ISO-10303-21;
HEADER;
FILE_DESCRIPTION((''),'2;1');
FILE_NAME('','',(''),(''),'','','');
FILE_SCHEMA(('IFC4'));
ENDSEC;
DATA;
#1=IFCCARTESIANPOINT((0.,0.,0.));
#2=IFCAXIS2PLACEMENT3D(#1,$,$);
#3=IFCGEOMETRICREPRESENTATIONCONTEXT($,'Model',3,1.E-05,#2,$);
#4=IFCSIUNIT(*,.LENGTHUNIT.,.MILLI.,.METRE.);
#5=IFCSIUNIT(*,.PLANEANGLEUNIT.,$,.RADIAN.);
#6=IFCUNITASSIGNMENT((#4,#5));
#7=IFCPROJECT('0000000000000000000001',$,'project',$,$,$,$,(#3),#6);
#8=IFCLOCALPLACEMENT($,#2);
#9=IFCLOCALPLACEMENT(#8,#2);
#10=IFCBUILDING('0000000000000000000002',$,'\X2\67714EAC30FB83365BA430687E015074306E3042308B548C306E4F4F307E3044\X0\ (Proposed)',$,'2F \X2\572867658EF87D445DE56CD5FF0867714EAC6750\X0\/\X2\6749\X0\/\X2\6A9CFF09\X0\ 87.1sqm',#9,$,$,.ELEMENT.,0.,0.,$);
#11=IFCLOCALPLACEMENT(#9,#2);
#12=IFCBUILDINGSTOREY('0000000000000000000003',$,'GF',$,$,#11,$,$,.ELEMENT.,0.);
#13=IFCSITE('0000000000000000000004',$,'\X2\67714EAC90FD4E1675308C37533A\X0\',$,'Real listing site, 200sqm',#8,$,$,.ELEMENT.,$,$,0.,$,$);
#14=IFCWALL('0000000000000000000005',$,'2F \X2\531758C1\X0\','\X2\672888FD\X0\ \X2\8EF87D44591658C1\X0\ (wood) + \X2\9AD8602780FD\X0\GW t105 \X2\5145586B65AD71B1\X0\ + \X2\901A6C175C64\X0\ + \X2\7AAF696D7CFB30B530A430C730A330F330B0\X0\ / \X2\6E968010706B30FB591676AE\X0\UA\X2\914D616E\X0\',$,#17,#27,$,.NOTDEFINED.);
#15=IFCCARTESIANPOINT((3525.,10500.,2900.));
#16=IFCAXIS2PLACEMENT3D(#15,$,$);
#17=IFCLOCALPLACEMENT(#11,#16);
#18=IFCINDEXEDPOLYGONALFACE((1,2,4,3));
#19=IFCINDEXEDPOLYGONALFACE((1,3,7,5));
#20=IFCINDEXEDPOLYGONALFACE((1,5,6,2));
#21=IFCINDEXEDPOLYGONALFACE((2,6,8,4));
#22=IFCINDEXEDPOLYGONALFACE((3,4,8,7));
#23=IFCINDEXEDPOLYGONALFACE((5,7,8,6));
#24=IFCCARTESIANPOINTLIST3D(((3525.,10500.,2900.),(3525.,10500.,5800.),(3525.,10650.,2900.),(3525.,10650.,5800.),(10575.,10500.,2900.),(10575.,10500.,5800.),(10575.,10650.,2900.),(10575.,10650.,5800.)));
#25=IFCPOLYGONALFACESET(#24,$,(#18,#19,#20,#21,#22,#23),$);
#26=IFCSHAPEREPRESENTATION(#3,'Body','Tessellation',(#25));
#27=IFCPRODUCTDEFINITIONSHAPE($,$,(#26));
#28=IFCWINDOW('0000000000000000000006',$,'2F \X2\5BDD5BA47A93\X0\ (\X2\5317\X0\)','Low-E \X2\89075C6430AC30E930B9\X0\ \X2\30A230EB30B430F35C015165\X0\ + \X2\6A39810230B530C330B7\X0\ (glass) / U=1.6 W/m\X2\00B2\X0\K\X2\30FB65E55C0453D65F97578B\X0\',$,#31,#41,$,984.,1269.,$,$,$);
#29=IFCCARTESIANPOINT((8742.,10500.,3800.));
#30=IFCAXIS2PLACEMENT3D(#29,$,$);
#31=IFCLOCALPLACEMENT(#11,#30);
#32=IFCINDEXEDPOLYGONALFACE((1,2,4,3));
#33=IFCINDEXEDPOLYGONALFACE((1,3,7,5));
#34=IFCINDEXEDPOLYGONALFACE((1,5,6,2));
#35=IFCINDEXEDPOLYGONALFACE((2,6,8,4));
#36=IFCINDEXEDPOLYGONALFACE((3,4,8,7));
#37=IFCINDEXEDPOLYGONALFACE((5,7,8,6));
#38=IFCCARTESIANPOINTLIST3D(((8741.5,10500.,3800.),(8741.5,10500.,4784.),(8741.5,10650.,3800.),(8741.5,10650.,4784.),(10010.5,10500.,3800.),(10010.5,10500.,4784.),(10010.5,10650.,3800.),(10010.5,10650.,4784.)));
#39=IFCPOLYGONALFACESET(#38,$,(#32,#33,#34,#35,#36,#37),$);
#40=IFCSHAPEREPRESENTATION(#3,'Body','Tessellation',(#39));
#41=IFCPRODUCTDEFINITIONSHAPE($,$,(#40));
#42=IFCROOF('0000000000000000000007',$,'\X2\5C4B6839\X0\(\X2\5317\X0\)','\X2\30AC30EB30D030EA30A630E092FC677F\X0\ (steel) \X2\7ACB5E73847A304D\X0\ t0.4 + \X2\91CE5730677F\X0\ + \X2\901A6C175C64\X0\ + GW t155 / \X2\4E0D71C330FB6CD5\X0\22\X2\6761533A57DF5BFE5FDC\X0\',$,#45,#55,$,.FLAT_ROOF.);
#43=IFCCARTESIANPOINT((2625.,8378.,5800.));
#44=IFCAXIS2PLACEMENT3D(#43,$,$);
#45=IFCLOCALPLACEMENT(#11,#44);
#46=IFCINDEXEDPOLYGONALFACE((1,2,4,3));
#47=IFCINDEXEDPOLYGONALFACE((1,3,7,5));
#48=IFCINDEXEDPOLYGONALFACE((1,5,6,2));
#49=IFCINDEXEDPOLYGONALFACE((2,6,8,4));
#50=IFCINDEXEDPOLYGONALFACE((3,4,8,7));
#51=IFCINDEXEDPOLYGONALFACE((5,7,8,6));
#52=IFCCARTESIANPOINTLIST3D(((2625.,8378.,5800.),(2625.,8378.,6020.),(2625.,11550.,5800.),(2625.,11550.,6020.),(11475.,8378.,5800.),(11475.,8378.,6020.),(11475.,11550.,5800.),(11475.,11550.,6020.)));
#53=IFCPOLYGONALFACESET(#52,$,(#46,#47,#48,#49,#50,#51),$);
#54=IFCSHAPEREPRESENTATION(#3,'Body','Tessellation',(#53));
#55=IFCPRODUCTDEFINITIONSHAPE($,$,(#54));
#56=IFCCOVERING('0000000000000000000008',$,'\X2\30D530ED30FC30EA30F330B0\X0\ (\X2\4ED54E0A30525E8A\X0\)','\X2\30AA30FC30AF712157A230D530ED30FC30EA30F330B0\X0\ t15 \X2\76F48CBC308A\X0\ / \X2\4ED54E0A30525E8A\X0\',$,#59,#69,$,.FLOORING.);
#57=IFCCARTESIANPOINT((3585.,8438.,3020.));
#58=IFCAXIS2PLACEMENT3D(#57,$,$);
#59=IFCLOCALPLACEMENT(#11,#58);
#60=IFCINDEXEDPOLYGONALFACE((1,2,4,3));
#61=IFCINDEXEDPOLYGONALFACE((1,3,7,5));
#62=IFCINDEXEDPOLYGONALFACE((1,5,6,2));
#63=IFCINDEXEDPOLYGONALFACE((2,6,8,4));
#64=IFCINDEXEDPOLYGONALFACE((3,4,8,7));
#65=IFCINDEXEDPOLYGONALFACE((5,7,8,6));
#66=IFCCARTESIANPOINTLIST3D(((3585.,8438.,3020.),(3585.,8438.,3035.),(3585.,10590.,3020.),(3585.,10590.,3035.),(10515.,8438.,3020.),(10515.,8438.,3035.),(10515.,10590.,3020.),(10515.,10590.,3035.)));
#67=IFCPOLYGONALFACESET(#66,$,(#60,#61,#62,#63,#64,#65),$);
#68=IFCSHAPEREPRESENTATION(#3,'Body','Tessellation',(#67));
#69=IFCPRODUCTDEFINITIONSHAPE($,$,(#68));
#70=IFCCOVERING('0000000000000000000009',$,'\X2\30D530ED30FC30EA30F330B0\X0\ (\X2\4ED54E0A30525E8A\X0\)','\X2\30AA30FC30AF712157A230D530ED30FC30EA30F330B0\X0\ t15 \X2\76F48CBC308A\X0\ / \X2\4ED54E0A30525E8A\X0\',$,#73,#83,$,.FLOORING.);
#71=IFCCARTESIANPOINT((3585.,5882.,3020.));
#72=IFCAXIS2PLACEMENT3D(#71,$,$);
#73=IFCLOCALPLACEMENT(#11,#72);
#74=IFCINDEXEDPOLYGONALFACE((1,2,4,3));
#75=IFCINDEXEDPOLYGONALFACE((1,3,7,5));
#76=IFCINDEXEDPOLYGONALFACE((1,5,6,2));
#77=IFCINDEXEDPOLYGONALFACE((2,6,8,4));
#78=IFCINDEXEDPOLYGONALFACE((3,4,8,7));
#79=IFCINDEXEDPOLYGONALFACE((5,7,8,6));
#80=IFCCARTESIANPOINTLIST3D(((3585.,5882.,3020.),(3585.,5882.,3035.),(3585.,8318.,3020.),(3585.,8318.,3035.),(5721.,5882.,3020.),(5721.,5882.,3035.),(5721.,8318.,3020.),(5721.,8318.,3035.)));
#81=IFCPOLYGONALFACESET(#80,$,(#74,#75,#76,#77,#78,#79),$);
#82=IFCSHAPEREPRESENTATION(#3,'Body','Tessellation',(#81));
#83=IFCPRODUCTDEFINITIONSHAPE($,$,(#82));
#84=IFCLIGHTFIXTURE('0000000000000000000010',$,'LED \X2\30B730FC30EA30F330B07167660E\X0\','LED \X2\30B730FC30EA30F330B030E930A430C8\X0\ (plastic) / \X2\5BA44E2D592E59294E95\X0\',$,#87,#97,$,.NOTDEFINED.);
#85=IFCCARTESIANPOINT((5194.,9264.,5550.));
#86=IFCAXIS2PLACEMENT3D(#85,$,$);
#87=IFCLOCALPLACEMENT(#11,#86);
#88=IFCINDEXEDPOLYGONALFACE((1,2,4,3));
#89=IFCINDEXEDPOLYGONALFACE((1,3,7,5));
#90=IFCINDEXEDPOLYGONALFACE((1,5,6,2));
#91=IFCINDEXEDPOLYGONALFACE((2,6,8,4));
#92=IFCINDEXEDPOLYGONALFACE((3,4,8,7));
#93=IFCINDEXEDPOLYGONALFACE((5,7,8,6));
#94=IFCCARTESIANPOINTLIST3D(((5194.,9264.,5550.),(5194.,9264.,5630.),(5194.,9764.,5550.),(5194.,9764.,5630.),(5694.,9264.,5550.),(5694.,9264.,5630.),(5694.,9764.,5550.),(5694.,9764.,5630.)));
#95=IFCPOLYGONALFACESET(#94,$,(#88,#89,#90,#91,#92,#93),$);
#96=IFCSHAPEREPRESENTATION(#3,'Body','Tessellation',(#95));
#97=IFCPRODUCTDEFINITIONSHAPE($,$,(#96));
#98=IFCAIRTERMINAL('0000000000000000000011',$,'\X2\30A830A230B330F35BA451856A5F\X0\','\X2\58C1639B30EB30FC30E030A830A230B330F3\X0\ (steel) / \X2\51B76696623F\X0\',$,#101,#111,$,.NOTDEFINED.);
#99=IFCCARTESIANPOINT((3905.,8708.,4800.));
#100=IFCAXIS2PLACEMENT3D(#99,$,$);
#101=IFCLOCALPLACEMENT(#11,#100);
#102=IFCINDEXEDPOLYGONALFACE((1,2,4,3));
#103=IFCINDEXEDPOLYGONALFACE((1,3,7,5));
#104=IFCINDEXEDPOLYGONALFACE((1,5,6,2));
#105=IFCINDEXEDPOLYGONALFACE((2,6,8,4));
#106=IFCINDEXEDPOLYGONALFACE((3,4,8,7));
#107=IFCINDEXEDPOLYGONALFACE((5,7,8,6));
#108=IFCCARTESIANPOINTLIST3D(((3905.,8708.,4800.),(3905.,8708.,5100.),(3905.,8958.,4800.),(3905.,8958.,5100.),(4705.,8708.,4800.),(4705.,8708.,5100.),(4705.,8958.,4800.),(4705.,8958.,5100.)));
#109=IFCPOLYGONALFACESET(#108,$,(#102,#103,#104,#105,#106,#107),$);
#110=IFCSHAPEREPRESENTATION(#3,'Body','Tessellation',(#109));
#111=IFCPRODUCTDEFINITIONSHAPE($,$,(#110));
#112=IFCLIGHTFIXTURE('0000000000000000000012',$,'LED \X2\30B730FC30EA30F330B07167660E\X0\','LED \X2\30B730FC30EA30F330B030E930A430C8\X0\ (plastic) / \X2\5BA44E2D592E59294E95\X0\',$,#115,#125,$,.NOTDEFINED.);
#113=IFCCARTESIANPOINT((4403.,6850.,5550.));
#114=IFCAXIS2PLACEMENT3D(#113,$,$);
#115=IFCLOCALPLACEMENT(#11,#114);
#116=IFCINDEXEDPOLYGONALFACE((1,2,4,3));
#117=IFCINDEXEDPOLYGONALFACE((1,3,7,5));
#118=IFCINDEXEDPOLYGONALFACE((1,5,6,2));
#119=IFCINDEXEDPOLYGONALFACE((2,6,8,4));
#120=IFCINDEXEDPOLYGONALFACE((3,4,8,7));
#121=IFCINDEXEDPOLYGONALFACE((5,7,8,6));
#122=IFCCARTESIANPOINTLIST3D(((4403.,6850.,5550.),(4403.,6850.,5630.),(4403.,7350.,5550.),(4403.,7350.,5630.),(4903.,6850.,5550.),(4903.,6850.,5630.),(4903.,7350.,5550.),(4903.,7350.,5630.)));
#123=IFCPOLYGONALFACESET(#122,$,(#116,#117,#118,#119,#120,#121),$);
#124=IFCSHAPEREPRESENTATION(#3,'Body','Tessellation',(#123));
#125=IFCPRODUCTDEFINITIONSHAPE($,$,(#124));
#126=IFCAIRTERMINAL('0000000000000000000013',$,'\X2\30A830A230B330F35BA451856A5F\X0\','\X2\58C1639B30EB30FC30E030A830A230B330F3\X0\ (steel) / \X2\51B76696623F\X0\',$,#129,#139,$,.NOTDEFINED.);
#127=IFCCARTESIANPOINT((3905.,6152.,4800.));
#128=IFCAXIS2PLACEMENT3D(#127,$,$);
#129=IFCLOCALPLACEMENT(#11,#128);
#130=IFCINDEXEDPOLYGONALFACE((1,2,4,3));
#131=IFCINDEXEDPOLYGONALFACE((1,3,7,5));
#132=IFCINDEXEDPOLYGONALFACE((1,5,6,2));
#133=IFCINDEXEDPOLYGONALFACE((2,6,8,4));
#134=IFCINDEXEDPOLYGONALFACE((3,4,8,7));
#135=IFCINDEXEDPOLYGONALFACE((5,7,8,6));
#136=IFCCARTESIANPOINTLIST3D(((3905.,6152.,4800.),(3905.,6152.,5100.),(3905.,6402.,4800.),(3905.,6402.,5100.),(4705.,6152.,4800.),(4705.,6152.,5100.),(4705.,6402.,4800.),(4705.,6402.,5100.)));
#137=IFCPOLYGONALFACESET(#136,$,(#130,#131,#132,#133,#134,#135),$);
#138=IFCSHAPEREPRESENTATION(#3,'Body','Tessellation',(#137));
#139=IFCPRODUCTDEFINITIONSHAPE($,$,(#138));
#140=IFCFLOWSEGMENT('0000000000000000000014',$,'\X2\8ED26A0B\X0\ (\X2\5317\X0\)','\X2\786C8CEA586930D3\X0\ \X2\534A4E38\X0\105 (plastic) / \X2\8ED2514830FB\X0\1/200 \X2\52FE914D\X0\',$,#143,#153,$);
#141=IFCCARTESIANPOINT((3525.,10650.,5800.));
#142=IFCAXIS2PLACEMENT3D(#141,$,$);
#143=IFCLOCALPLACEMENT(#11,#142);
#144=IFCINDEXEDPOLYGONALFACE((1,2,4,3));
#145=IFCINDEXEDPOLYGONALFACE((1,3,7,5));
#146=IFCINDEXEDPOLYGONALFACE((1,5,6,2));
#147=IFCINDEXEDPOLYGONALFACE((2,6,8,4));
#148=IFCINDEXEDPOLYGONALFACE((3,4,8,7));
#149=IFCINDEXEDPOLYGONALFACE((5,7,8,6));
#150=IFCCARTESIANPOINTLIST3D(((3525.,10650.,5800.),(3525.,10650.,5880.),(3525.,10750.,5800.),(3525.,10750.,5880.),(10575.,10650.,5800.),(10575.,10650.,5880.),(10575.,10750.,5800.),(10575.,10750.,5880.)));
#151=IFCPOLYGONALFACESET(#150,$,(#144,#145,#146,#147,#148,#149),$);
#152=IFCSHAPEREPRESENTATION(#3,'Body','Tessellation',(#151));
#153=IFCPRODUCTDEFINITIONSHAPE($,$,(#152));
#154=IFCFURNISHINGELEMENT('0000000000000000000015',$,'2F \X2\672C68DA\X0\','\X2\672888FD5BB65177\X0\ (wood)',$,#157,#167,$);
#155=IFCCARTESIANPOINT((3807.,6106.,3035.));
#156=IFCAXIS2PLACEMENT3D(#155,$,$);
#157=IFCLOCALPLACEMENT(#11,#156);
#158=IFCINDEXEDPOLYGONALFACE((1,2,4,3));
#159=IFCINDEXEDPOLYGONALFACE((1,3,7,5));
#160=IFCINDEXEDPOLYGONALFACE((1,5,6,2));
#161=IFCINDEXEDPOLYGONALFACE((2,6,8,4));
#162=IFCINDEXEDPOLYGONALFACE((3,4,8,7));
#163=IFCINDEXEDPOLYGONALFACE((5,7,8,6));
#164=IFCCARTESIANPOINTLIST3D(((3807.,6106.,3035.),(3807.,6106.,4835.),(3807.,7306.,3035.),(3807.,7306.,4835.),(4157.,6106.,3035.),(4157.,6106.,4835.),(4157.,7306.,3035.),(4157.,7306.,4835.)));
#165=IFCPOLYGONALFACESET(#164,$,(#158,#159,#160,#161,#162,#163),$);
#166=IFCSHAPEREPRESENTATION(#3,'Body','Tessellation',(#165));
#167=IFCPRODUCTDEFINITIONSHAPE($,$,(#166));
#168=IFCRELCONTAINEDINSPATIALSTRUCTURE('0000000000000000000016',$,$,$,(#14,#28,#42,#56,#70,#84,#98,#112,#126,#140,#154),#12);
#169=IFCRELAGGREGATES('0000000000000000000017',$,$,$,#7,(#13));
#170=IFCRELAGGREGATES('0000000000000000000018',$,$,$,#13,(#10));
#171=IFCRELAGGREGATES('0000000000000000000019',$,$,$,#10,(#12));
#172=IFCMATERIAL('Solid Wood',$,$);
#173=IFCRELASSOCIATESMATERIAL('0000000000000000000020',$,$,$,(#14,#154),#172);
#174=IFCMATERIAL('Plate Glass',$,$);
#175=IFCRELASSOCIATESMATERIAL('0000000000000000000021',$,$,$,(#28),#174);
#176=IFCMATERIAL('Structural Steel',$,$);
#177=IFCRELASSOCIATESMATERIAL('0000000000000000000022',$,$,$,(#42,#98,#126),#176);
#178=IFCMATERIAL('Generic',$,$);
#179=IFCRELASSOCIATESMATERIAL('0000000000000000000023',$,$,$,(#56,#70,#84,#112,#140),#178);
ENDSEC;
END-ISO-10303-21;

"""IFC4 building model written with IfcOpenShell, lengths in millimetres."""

from ifc_helpers import new_model, si_unit, frame, frame_2d, origin, place, context, project, spatial, rectangle, extrude, material, element, fill, save


model = new_model("IFC4")

# Units and contexts
model_context = context("Model", 3, precision=1e-05, world=origin())
ifc_project = project(units=[si_unit("LENGTHUNIT", "METRE", prefix="MILLI"), si_unit("PLANEANGLEUNIT", "RADIAN")], contexts=[model_context])

# Site, building, storey
site_placement = place(None, origin())
site = spatial("IfcSite", under=ifc_project, at=site_placement, Name="東京都世田谷区", ObjectType="Real listing site, 200sqm", CompositionType="ELEMENT", RefElevation=0.0)
building_placement = place(site_placement, origin())
building = spatial("IfcBuilding", under=site, at=building_placement, Name="東京・茶室と縁側のある和の住まい (Proposed)", ObjectType="2F 在来軸組工法（東京材/杉/檜） 87.1sqm", CompositionType="ELEMENT", ElevationOfRefHeight=0.0, ElevationOfTerrain=0.0)
storey_placement = place(building_placement, origin())
storey = spatial("IfcBuildingStorey", under=building, at=storey_placement, Name="GF", CompositionType="ELEMENT", Elevation=0.0)

# Shared definitions
ifc_material_1 = material(Name="Solid Wood")

# Wall, opening, window
wall_placement = place(storey_placement, frame((3525.0, 10500.0, 2900.0)))
wall = element("IfcWall", 1, at=wall_placement, inside=storey, material=ifc_material_1, Name="2F 北壁", Description="木製 軸組外壁 (wood) + 高性能GW t105 充填断熱 + 通気層 + 窯業系サイディング / 準耐火・外皮UA配慮", PredefinedType="NOTDEFINED", context=model_context, shape_type="SweptSolid", body=[
    extrude(rectangle(XDim=7050.0, YDim=150.0, at=frame_2d((3525.0, 75.0))), frame((3525.0, 10500.0, 2900.0)), (0.0, 0.0, 1.0), 2900.0),
])
opening_placement = place(storey_placement, frame((8742.0, 10500.0, 3800.0)))
opening = element("IfcOpeningElement", 2, at=opening_placement, cuts=wall, PredefinedType="NOTDEFINED", context=model_context, shape_type="SweptSolid", body=[
    extrude(rectangle(XDim=1269.0, YDim=150.0, at=frame_2d((634.0, 75.0))), frame((8742.0, 10500.0, 3800.0)), (0.0, 0.0, 1.0), 984.0),
])
ifc_material_2 = material(Name="Plate Glass")
window_placement = place(storey_placement, frame((8742.0, 10500.0, 3800.0)))
window = element("IfcWindow", 3, at=window_placement, inside=storey, material=ifc_material_2, Name="2F 寝室窓 (北)", Description="Low-E 複層ガラス アルゴン封入 + 樹脂サッシ (glass) / U=1.6 W/m²K・日射取得型", OverallHeight=984.0, OverallWidth=1269.0, context=model_context, shape_type="SweptSolid", body=[
    extrude(rectangle(XDim=1269.0, YDim=150.0, at=frame_2d((634.0, 75.0))), frame((8742.0, 10500.0, 3800.0)), (0.0, 0.0, 1.0), 984.0),
])
fill(opening, window)

# Roof
ifc_material_3 = material(Name="Structural Steel")
for number, where, name in (
    (4, (2625.0, 8378.0, 5800.0), "屋根(北)"),
):
    element("IfcRoof", number, at=place(storey_placement, frame(where)), inside=storey, material=ifc_material_3, Name=name, Description="ガルバリウム鋼板 (steel) 立平葺き t0.4 + 野地板 + 通気層 + GW t155 / 不燃・法22条区域対応", PredefinedType="FLAT_ROOF", context=model_context, shape_type="SweptSolid", body=[
        extrude(rectangle(XDim=8850.0, YDim=3172.0, at=frame_2d((4425.0, 1586.0))), frame((2625.0, 8378.0, 5800.0)), (0.0, 0.0, 1.0), 220.0),
    ])

# Coverings
ifc_material_4 = material(Name="Generic")
covering_1_placement = place(storey_placement, frame((3585.0, 8438.0, 3020.0)))
element("IfcCovering", 5, at=covering_1_placement, inside=storey, material=ifc_material_4, Name="フローリング (仕上げ床)", Description="オーク無垢フローリング t15 直貼り / 仕上げ床", PredefinedType="FLOORING", context=model_context, shape_type="SweptSolid", body=[
    extrude(rectangle(XDim=6930.0, YDim=2152.0, at=frame_2d((3465.0, 1076.0))), frame((3585.0, 8438.0, 3020.0)), (0.0, 0.0, 1.0), 15.0),
])
covering_2_placement = place(storey_placement, frame((3585.0, 5882.0, 3020.0)))
element("IfcCovering", 6, at=covering_2_placement, inside=storey, material=ifc_material_4, Name="フローリング (仕上げ床)", Description="オーク無垢フローリング t15 直貼り / 仕上げ床", PredefinedType="FLOORING", context=model_context, shape_type="SweptSolid", body=[
    extrude(rectangle(XDim=2136.0, YDim=2436.0, at=frame_2d((1068.0, 1218.0))), frame((3585.0, 5882.0, 3020.0)), (0.0, 0.0, 1.0), 15.0),
])

# Light fixture
light_fixture_1_placement = place(storey_placement, frame((5194.0, 9264.0, 5550.0)))
element("IfcLightFixture", 7, at=light_fixture_1_placement, inside=storey, material=ifc_material_4, Name="LED シーリング照明", Description="LED シーリングライト (plastic) / 室中央天井", PredefinedType="NOTDEFINED", context=model_context, shape_type="SweptSolid", body=[
    extrude(rectangle(XDim=500.0, YDim=500.0, at=frame_2d((250.0, 250.0))), frame((5194.0, 9264.0, 5550.0)), (0.0, 0.0, 1.0), 80.0),
])

# Air terminal
air_terminal_1_placement = place(storey_placement, frame((3905.0, 8708.0, 4800.0)))
element("IfcAirTerminal", 8, at=air_terminal_1_placement, inside=storey, material=ifc_material_3, Name="エアコン室内機", Description="壁掛ルームエアコン (steel) / 冷暖房", PredefinedType="NOTDEFINED", context=model_context, shape_type="SweptSolid", body=[
    extrude(rectangle(XDim=800.0, YDim=250.0, at=frame_2d((400.0, 125.0))), frame((3905.0, 8708.0, 4800.0)), (0.0, 0.0, 1.0), 300.0),
])

# Light fixture
light_fixture_2_placement = place(storey_placement, frame((4403.0, 6850.0, 5550.0)))
element("IfcLightFixture", 9, at=light_fixture_2_placement, inside=storey, material=ifc_material_4, Name="LED シーリング照明", Description="LED シーリングライト (plastic) / 室中央天井", PredefinedType="NOTDEFINED", context=model_context, shape_type="SweptSolid", body=[
    extrude(rectangle(XDim=500.0, YDim=500.0, at=frame_2d((250.0, 250.0))), frame((4403.0, 6850.0, 5550.0)), (0.0, 0.0, 1.0), 80.0),
])

# Air terminal
air_terminal_2_placement = place(storey_placement, frame((3905.0, 6152.0, 4800.0)))
element("IfcAirTerminal", 10, at=air_terminal_2_placement, inside=storey, material=ifc_material_3, Name="エアコン室内機", Description="壁掛ルームエアコン (steel) / 冷暖房", PredefinedType="NOTDEFINED", context=model_context, shape_type="SweptSolid", body=[
    extrude(rectangle(XDim=800.0, YDim=250.0, at=frame_2d((400.0, 125.0))), frame((3905.0, 6152.0, 4800.0)), (0.0, 0.0, 1.0), 300.0),
])

# Flow segment
flow_segment_placement = place(storey_placement, frame((3525.0, 10650.0, 5800.0)))
element("IfcFlowSegment", 11, at=flow_segment_placement, inside=storey, material=ifc_material_4, Name="軒樋 (北)", Description="硬質塩ビ 半丸105 (plastic) / 軒先・1/200 勾配", context=model_context, shape_type="SweptSolid", body=[
    extrude(rectangle(XDim=7050.0, YDim=100.0, at=frame_2d((3525.0, 50.0))), frame((3525.0, 10650.0, 5800.0)), (0.0, 0.0, 1.0), 80.0),
])

# Furnishing element
furnishing_placement = place(storey_placement, frame((3807.0, 6106.0, 3035.0)))
element("IfcFurnishingElement", 12, at=furnishing_placement, inside=storey, material=ifc_material_1, Name="2F 本棚", Description="木製家具 (wood)", context=model_context, shape_type="SweptSolid", body=[
    extrude(rectangle(XDim=350.0, YDim=1200.0, at=frame_2d((175.0, 600.0))), frame((3807.0, 6106.0, 3035.0)), (0.0, 0.0, 1.0), 1800.0),
])

save(model, "model.ifc")
